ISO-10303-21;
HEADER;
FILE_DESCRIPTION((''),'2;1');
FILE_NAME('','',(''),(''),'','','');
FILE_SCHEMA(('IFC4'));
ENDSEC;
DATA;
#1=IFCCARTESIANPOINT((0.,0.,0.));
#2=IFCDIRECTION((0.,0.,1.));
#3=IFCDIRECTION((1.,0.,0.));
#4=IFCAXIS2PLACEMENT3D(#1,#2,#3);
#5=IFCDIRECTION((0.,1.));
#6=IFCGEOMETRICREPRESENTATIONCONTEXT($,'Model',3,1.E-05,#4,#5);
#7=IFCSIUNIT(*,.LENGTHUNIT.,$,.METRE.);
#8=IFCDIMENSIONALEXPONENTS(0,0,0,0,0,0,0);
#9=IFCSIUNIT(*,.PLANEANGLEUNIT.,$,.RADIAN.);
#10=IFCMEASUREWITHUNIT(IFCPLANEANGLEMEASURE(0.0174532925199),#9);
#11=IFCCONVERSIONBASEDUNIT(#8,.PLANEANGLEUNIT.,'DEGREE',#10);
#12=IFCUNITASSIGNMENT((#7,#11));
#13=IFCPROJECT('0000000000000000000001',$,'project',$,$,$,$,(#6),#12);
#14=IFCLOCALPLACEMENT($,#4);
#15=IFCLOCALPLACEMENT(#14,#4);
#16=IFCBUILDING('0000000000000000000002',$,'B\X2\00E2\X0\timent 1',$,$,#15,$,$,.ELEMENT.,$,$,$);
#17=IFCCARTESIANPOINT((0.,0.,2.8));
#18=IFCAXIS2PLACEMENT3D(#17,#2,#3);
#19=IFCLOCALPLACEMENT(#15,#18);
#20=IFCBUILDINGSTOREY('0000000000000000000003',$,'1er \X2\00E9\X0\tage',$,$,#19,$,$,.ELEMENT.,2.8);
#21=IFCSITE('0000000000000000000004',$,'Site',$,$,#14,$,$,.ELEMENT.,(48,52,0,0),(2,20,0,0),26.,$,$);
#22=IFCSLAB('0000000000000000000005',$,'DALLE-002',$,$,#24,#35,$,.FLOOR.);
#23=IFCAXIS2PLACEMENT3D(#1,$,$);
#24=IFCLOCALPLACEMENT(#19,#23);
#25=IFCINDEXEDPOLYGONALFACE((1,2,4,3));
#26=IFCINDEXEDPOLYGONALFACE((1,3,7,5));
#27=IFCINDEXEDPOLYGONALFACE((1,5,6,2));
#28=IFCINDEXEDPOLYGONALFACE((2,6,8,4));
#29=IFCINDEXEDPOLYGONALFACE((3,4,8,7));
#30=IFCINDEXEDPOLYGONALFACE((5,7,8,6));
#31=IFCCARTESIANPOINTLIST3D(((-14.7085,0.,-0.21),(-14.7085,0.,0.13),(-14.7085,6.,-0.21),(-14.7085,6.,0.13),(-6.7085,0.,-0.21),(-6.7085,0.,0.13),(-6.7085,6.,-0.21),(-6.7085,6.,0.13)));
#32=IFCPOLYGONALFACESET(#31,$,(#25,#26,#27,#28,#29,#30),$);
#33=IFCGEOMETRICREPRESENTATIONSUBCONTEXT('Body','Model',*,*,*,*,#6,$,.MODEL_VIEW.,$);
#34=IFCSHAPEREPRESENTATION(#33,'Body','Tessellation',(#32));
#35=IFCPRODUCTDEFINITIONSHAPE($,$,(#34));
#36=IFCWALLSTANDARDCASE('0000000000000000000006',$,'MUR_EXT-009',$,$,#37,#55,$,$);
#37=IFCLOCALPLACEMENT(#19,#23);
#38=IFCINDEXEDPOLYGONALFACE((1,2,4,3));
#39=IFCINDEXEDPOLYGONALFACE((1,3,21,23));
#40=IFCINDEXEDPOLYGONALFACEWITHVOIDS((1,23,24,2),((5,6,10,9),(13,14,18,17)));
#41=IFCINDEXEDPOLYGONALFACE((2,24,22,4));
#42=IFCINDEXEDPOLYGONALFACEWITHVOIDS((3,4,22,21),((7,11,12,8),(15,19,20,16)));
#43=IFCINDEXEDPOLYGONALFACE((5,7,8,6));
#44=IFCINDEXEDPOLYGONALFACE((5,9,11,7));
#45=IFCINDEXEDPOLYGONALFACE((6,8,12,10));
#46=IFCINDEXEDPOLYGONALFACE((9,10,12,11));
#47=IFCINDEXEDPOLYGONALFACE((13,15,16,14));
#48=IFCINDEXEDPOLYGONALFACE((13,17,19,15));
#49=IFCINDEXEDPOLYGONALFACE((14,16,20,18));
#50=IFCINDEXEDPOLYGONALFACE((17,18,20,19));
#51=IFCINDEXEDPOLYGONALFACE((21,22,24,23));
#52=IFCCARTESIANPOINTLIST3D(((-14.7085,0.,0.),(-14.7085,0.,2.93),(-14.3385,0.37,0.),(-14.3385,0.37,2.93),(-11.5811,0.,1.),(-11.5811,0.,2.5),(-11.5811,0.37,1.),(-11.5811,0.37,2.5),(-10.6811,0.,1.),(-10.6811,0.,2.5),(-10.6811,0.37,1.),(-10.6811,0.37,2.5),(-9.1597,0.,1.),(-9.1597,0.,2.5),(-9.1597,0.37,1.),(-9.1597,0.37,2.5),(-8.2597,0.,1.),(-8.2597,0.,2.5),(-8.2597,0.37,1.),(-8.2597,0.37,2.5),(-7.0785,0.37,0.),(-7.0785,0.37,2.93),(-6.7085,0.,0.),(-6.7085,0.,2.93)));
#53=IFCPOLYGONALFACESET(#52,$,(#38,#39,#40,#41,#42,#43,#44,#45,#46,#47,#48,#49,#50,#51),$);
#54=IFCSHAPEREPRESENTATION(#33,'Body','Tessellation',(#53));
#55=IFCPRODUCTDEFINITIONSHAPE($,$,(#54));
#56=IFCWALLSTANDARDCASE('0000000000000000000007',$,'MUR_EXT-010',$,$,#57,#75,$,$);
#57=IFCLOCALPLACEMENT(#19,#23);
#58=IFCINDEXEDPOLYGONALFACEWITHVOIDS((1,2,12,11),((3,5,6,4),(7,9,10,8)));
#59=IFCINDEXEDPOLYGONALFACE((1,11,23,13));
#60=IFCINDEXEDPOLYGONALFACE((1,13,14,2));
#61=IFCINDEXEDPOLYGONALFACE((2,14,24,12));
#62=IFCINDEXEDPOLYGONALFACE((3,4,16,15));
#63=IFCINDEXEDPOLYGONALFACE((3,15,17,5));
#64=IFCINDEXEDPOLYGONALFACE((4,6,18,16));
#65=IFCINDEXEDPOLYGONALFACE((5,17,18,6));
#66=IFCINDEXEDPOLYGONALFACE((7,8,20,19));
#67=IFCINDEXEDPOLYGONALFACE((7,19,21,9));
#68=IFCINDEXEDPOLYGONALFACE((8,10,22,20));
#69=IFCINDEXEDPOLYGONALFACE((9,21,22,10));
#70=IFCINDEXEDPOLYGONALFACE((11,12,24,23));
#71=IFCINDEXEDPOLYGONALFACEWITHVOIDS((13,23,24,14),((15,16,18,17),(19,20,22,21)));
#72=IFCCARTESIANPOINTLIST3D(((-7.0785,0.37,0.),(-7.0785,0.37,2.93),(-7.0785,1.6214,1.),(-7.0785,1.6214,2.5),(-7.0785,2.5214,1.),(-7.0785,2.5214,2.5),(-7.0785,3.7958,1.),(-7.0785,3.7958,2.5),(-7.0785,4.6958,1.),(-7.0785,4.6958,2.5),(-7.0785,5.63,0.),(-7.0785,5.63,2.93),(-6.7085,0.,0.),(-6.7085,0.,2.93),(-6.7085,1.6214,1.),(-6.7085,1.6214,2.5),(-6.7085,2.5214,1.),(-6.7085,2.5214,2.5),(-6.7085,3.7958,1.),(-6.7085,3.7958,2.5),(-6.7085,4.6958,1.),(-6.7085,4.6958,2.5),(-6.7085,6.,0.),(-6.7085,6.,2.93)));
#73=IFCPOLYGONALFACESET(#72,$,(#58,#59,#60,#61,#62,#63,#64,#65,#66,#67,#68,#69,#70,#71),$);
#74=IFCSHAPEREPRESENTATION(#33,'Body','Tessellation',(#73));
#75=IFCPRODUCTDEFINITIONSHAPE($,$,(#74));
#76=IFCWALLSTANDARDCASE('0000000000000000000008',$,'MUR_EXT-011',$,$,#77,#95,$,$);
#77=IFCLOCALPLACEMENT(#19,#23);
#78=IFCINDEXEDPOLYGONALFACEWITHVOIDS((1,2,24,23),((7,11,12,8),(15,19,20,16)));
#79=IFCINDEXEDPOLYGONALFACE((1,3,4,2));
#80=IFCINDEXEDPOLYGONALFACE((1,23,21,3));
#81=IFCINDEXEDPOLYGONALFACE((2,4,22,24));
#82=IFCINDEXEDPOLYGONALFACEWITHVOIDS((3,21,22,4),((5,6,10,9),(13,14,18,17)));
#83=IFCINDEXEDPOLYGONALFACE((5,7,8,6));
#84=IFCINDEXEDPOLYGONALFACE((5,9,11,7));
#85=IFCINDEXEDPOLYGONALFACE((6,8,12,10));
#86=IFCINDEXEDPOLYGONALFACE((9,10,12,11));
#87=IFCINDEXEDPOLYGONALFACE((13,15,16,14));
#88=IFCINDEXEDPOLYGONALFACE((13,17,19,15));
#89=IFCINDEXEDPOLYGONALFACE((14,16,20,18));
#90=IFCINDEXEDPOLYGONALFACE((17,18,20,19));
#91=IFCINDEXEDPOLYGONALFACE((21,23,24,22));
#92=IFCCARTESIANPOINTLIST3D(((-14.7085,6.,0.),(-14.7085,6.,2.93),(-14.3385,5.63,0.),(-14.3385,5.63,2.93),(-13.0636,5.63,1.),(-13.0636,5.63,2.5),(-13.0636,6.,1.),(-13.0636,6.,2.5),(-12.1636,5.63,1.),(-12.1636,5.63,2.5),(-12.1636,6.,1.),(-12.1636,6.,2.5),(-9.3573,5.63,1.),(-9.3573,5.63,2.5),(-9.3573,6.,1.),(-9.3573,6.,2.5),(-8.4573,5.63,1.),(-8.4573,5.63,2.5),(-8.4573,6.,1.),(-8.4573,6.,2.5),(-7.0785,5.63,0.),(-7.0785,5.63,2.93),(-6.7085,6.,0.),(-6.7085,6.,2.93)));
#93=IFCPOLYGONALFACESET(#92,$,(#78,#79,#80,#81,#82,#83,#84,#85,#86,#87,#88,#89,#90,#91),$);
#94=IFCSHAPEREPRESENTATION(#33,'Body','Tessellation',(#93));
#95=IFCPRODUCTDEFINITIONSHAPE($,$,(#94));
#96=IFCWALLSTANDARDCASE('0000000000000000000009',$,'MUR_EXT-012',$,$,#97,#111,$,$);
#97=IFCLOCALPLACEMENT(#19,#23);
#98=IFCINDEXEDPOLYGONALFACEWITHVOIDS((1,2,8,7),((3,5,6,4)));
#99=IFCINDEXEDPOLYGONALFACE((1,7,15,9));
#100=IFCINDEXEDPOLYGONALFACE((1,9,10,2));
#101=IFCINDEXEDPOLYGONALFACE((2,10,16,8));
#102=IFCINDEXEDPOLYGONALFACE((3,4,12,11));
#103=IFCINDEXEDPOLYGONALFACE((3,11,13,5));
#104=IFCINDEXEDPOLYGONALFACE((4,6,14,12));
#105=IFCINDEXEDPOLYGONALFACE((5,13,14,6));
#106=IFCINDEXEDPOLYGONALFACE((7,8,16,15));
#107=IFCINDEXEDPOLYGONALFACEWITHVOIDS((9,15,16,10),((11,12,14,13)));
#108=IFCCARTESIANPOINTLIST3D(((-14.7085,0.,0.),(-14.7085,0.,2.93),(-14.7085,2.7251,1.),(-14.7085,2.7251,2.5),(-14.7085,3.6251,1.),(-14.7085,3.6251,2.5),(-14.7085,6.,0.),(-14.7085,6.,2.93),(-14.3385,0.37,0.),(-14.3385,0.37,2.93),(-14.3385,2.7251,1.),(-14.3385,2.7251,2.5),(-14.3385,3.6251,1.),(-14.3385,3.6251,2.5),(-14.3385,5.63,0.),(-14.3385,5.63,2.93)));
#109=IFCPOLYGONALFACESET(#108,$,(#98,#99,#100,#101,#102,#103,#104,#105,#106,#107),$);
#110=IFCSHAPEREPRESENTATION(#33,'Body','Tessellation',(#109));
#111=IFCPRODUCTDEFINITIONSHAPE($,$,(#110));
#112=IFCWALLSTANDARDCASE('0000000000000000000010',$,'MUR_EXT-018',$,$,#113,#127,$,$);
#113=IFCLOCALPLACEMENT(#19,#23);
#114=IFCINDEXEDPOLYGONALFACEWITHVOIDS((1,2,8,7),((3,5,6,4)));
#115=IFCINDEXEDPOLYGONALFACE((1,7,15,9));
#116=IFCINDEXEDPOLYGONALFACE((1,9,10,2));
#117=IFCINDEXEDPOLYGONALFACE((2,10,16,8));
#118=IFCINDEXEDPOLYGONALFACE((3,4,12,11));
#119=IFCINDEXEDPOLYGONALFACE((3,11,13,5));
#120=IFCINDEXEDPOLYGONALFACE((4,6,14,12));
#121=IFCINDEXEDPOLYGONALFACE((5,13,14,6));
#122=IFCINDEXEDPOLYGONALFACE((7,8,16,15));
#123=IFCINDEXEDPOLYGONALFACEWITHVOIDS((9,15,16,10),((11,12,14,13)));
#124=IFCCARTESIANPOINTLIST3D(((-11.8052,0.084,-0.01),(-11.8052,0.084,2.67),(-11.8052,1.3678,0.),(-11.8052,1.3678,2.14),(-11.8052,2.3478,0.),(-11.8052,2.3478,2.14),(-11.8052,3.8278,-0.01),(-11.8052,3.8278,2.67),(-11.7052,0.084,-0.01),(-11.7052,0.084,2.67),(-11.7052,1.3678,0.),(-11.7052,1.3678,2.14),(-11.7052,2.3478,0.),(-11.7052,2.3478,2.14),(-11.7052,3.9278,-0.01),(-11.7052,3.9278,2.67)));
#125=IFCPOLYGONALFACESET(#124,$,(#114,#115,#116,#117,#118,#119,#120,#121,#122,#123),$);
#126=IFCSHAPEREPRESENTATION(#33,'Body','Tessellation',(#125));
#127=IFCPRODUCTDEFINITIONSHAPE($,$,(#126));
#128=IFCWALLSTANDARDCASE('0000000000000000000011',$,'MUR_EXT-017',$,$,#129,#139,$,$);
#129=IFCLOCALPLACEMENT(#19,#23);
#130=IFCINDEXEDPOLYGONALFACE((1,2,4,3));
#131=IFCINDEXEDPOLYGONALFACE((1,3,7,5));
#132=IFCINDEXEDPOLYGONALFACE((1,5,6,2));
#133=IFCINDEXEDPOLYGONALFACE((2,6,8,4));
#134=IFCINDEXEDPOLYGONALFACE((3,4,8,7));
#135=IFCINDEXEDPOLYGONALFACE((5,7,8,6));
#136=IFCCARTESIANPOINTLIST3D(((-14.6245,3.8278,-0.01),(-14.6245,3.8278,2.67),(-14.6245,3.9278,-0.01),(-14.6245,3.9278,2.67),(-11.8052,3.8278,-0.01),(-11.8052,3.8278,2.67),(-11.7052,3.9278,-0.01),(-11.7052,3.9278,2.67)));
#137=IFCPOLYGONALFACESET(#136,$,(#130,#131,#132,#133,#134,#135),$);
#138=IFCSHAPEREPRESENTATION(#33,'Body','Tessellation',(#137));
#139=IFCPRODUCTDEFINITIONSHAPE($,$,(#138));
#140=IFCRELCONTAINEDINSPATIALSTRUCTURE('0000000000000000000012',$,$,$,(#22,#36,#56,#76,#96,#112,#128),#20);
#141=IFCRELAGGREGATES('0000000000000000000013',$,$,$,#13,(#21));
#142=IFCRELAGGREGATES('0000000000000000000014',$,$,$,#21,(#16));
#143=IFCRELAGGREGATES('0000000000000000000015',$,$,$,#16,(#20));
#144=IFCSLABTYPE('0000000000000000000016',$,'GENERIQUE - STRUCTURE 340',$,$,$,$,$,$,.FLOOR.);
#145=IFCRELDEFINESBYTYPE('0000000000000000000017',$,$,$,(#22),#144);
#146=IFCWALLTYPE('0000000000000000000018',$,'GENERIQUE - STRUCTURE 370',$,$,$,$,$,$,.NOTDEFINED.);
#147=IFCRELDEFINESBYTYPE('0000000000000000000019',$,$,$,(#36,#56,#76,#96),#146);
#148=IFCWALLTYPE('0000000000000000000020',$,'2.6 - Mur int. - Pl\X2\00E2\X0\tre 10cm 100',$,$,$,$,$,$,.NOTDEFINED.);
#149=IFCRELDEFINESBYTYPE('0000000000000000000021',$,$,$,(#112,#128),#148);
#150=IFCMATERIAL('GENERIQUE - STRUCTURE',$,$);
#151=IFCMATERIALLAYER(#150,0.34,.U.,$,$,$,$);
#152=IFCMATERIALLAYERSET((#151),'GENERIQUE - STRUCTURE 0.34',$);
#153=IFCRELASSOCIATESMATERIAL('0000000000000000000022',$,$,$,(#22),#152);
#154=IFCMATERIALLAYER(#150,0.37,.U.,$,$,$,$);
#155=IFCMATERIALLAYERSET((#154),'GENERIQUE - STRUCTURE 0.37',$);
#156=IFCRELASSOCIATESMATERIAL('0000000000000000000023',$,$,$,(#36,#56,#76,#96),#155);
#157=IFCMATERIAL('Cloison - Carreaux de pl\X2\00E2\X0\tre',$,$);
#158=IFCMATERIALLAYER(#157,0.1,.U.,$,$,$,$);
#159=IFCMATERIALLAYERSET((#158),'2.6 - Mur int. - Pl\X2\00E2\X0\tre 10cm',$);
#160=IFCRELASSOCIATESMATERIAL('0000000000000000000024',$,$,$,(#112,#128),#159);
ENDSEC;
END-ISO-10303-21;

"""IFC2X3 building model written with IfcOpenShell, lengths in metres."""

from ifc_helpers import new_model, entity, si_unit, converted_unit, direction, frame, origin_with_axes, origin_2d_with_axis, place, context, subcontext, project, spatial, polyline, rectangle, outline, extrude, clip, halfspace, material, layer, layer_set, layer_usage, type_object, element, save


model = new_model("IFC2X3")

# Units and contexts
model_context = context("Model", 3, precision=1e-05, world=origin_with_axes(), true_north=direction((0.0, 1.0)))
body_context = subcontext(model_context, "Body", "Model", "MODEL_VIEW")
ifc_project = project(units=[si_unit("LENGTHUNIT", "METRE"), converted_unit("PLANEANGLEUNIT", "DEGREE", entity("IfcPlaneAngleMeasure", 0.0174532925199), si_unit("PLANEANGLEUNIT", "RADIAN"), dimensions=[0, 0, 0, 0, 0, 0, 0])], contexts=[model_context])

# Site, building, storey
site_placement = place(None, origin_with_axes())
site = spatial("IfcSite", under=ifc_project, at=site_placement, Name="Site", CompositionType="ELEMENT", RefLatitude=(48, 52, 0, 0), RefLongitude=(2, 20, 0, 0), RefElevation=26.0)
building_placement = place(site_placement, origin_with_axes())
building = spatial("IfcBuilding", under=site, at=building_placement, Name="Bâtiment 1", CompositionType="ELEMENT")
storey_placement = place(building_placement, frame((0.0, 0.0, 2.8), z_axis=(0.0, 0.0, 1.0), x_axis=(1.0, 0.0, 0.0)))
storey = spatial("IfcBuildingStorey", under=building, at=storey_placement, Name="1er étage", CompositionType="ELEMENT", Elevation=2.8)

# Slab
ifc_material_1 = material(Name="GENERIQUE - STRUCTURE")
ifc_layer_1 = layer(ifc_material_1, 0.34, ventilated="UNKNOWN")
ifc_layer_set_1 = layer_set([ifc_layer_1], Name="GENERIQUE - STRUCTURE 0.34")
ifc_layer_usage_1 = layer_usage(ifc_layer_set_1, "AXIS3", "NEGATIVE", 0.34)
slab_type_1 = type_object("IfcSlabType", Name="GENERIQUE - STRUCTURE 340", PredefinedType="FLOOR")
slab_1_placement = place(storey_placement, frame((-14.7085, 0.0, 0.13), z_axis=(0.0, 0.0, 1.0), x_axis=(1.0, 0.0, 0.0)))
element("IfcSlab", 1, at=slab_1_placement, inside=storey, type_object=slab_type_1, material=ifc_layer_usage_1, Name="DALLE-002", PredefinedType="FLOOR", context=body_context, shape_type="SweptSolid", body=[
    extrude(outline(polyline([(0.0, 0.0), (8.0, 0.0), (8.0, 6.0), (0.0, 6.0), (0.0, 0.0)])), frame((0.0, 0.0, -0.34), z_axis=(0.0, 0.0, 1.0), x_axis=(1.0, 0.0, 0.0)), (0.0, 0.0, 1.0), 0.34),
])

# Walls, openings
ifc_layer_2 = layer(ifc_material_1, 0.37, ventilated="UNKNOWN")
ifc_layer_set_2 = layer_set([ifc_layer_2], Name="GENERIQUE - STRUCTURE 0.37")
ifc_layer_usage_2 = layer_usage(ifc_layer_set_2, "AXIS2", "POSITIVE", 0.0)
wall_type_1 = type_object("IfcWallType", Name="GENERIQUE - STRUCTURE 370", PredefinedType="NOTDEFINED")
wall_1_placement = place(storey_placement, frame((-14.7085, 0.0, 0.0), z_axis=(0.0, 0.0, 1.0), x_axis=(1.0, 0.0, 0.0)))
wall_1 = element("IfcWallStandardCase", 2, at=wall_1_placement, inside=storey, type_object=wall_type_1, material=ifc_layer_usage_2, Name="MUR_EXT-009", context=body_context, shape_type="Clipping", body=[
    clip(clip(extrude(outline(polyline([(0.0, 0.0), (8.0, 0.0), (7.63, 0.37), (0.37, 0.37), (0.0, 0.0)])), origin_with_axes(), (0.0, 0.0, 1.0), 3.211), halfspace(frame((0.0, 0.0, 2.93), z_axis=(0.0, 0.0, -1.0), x_axis=(0.0, 1.0, 0.0)), True)), halfspace(frame((0.0, 0.0, 2.93), z_axis=(0.0, 0.0, -1.0), x_axis=(0.0, 1.0, 0.0)), True)),
])
opening_1_placement = place(wall_1_placement, frame((5.9988, 0.0, 1.0), z_axis=(0.0, 0.0, 1.0), x_axis=(1.0, 0.0, 0.0)))
element("IfcOpeningElement", 3, at=opening_1_placement, cuts=wall_1, context=body_context, shape_type="SweptSolid", body=[
    extrude(rectangle(XDim=0.9, YDim=1.5, at=origin_2d_with_axis()), frame((0.0, 0.37, 0.75), z_axis=(0.0, -1.0, 0.0), x_axis=(-1.0, 0.0, 0.0)), (0.0, 0.0, 1.0), 1.11),
])
opening_2_placement = place(wall_1_placement, frame((3.5774, 0.0, 1.0), z_axis=(0.0, 0.0, 1.0), x_axis=(1.0, 0.0, 0.0)))
element("IfcOpeningElement", 4, at=opening_2_placement, cuts=wall_1, context=body_context, shape_type="SweptSolid", body=[
    extrude(rectangle(XDim=0.9, YDim=1.5, at=origin_2d_with_axis()), frame((0.0, 0.37, 0.75), z_axis=(0.0, -1.0, 0.0), x_axis=(-1.0, 0.0, 0.0)), (0.0, 0.0, 1.0), 1.11),
])
ifc_layer_usage_3 = layer_usage(ifc_layer_set_2, "AXIS2", "POSITIVE", 0.0)
wall_2_placement = place(storey_placement, frame((-6.7085, 0.0, 0.0), z_axis=(0.0, 0.0, 1.0), x_axis=(0.0, 1.0, 0.0)))
wall_2 = element("IfcWallStandardCase", 5, at=wall_2_placement, inside=storey, type_object=wall_type_1, material=ifc_layer_usage_3, Name="MUR_EXT-010", context=body_context, shape_type="SweptSolid", body=[
    extrude(outline(polyline([(0.0, 0.0), (6.0, 0.0), (5.63, 0.37), (0.37, 0.37), (0.0, 0.0)])), origin_with_axes(), (0.0, 0.0, 1.0), 2.93),
])
opening_3_placement = place(wall_2_placement, frame((4.2458, 0.0, 1.0), z_axis=(0.0, 0.0, 1.0), x_axis=(1.0, 0.0, 0.0)))
element("IfcOpeningElement", 6, at=opening_3_placement, cuts=wall_2, context=body_context, shape_type="SweptSolid", body=[
    extrude(rectangle(XDim=0.9, YDim=1.5, at=origin_2d_with_axis()), frame((0.0, 0.37, 0.75), z_axis=(0.0, -1.0, 0.0), x_axis=(-1.0, 0.0, 0.0)), (0.0, 0.0, 1.0), 1.11),
])
opening_4_placement = place(wall_2_placement, frame((2.0714, 0.0, 1.0), z_axis=(0.0, 0.0, 1.0), x_axis=(1.0, 0.0, 0.0)))
element("IfcOpeningElement", 7, at=opening_4_placement, cuts=wall_2, context=body_context, shape_type="SweptSolid", body=[
    extrude(rectangle(XDim=0.9, YDim=1.5, at=origin_2d_with_axis()), frame((0.0, 0.37, 0.75), z_axis=(0.0, -1.0, 0.0), x_axis=(-1.0, 0.0, 0.0)), (0.0, 0.0, 1.0), 1.11),
])
ifc_layer_usage_4 = layer_usage(ifc_layer_set_2, "AXIS2", "POSITIVE", 0.0)
wall_3_placement = place(storey_placement, frame((-6.7085, 6.0, 0.0), z_axis=(0.0, 0.0, 1.0), x_axis=(-1.0, 0.0, 0.0)))
wall_3 = element("IfcWallStandardCase", 8, at=wall_3_placement, inside=storey, type_object=wall_type_1, material=ifc_layer_usage_4, Name="MUR_EXT-011", context=body_context, shape_type="SweptSolid", body=[
    extrude(outline(polyline([(0.0, 0.0), (8.0, 0.0), (7.63, 0.37), (0.37, 0.37), (0.0, 0.0)])), origin_with_axes(), (0.0, 0.0, 1.0), 2.93),
])
opening_5_placement = place(wall_3_placement, frame((5.9051, 0.0, 1.0), z_axis=(0.0, 0.0, 1.0), x_axis=(1.0, 0.0, 0.0)))
element("IfcOpeningElement", 9, at=opening_5_placement, cuts=wall_3, context=body_context, shape_type="SweptSolid", body=[
    extrude(rectangle(XDim=0.9, YDim=1.5, at=origin_2d_with_axis()), frame((0.0, 0.37, 0.75), z_axis=(0.0, -1.0, 0.0), x_axis=(-1.0, 0.0, 0.0)), (0.0, 0.0, 1.0), 1.11),
])
opening_6_placement = place(wall_3_placement, frame((2.1988, 0.0, 1.0), z_axis=(0.0, 0.0, 1.0), x_axis=(1.0, 0.0, 0.0)))
element("IfcOpeningElement", 10, at=opening_6_placement, cuts=wall_3, context=body_context, shape_type="SweptSolid", body=[
    extrude(rectangle(XDim=0.9, YDim=1.5, at=origin_2d_with_axis()), frame((0.0, 0.37, 0.75), z_axis=(0.0, -1.0, 0.0), x_axis=(-1.0, 0.0, 0.0)), (0.0, 0.0, 1.0), 1.11),
])

# Walls, openings
ifc_layer_usage_5 = layer_usage(ifc_layer_set_2, "AXIS2", "POSITIVE", 0.0)
wall_4_placement = place(storey_placement, frame((-14.7085, 6.0, 0.0), z_axis=(0.0, 0.0, 1.0), x_axis=(0.0, -1.0, 0.0)))
wall_4 = element("IfcWallStandardCase", 11, at=wall_4_placement, inside=storey, type_object=wall_type_1, material=ifc_layer_usage_5, Name="MUR_EXT-012", context=body_context, shape_type="SweptSolid", body=[
    extrude(outline(polyline([(0.0, 0.0), (6.0, 0.0), (5.63, 0.37), (0.37, 0.37), (0.0, 0.0)])), origin_with_axes(), (0.0, 0.0, 1.0), 2.93),
])
opening_7_placement = place(wall_4_placement, frame((2.8249, 0.0, 1.0), z_axis=(0.0, 0.0, 1.0), x_axis=(1.0, 0.0, 0.0)))
element("IfcOpeningElement", 12, at=opening_7_placement, cuts=wall_4, context=body_context, shape_type="SweptSolid", body=[
    extrude(rectangle(XDim=0.9, YDim=1.5, at=origin_2d_with_axis()), frame((0.0, 0.37, 0.75), z_axis=(0.0, -1.0, 0.0), x_axis=(-1.0, 0.0, 0.0)), (0.0, 0.0, 1.0), 1.11),
])
ifc_material_2 = material(Name="Cloison - Carreaux de plâtre")
ifc_layer_3 = layer(ifc_material_2, 0.1, ventilated="UNKNOWN")
ifc_layer_set_3 = layer_set([ifc_layer_3], Name="2.6 - Mur int. - Plâtre 10cm")
ifc_layer_usage_6 = layer_usage(ifc_layer_set_3, "AXIS2", "POSITIVE", -0.05)
wall_type_2 = type_object("IfcWallType", Name="2.6 - Mur int. - Plâtre 10cm 100", PredefinedType="NOTDEFINED")
wall_5_placement = place(storey_placement, frame((-11.7552, 3.8778, -0.01), z_axis=(0.0, 0.0, 1.0), x_axis=(0.0, -1.0, 0.0)))
wall_5 = element("IfcWallStandardCase", 13, at=wall_5_placement, inside=storey, type_object=wall_type_2, material=ifc_layer_usage_6, Name="MUR_EXT-018", context=body_context, shape_type="SweptSolid", body=[
    extrude(outline(polyline([(0.05, -0.05), (3.7938, -0.05), (3.7938, 0.05), (-0.05, 0.05), (0.05, -0.05)])), origin_with_axes(), (0.0, 0.0, 1.0), 2.68),
])
opening_8_placement = place(wall_5_placement, frame((2.02, 0.0, 0.01), z_axis=(0.0, 0.0, 1.0), x_axis=(1.0, 0.0, 0.0)))
element("IfcOpeningElement", 14, at=opening_8_placement, cuts=wall_5, context=body_context, shape_type="SweptSolid", body=[
    extrude(rectangle(XDim=0.98, YDim=2.14, at=origin_2d_with_axis()), frame((0.0, -0.1, 1.07), z_axis=(0.0, -1.0, 0.0), x_axis=(-1.0, 0.0, 0.0)), (0.0, 0.0, -1.0), 0.3),
])

# Wall
ifc_layer_usage_7 = layer_usage(ifc_layer_set_3, "AXIS2", "POSITIVE", -0.05)
wall_6_placement = place(storey_placement, frame((-14.6245, 3.8778, -0.01), z_axis=(0.0, 0.0, 1.0), x_axis=(1.0, 0.0, 0.0)))
element("IfcWallStandardCase", 15, at=wall_6_placement, inside=storey, type_object=wall_type_2, material=ifc_layer_usage_7, Name="MUR_EXT-017", context=body_context, shape_type="SweptSolid", body=[
    extrude(outline(polyline([(0.0, -0.05), (2.8193, -0.05), (2.9193, 0.05), (0.0, 0.05), (0.0, -0.05)])), origin_with_axes(), (0.0, 0.0, 1.0), 2.68),
])

save(model, "model.ifc")
